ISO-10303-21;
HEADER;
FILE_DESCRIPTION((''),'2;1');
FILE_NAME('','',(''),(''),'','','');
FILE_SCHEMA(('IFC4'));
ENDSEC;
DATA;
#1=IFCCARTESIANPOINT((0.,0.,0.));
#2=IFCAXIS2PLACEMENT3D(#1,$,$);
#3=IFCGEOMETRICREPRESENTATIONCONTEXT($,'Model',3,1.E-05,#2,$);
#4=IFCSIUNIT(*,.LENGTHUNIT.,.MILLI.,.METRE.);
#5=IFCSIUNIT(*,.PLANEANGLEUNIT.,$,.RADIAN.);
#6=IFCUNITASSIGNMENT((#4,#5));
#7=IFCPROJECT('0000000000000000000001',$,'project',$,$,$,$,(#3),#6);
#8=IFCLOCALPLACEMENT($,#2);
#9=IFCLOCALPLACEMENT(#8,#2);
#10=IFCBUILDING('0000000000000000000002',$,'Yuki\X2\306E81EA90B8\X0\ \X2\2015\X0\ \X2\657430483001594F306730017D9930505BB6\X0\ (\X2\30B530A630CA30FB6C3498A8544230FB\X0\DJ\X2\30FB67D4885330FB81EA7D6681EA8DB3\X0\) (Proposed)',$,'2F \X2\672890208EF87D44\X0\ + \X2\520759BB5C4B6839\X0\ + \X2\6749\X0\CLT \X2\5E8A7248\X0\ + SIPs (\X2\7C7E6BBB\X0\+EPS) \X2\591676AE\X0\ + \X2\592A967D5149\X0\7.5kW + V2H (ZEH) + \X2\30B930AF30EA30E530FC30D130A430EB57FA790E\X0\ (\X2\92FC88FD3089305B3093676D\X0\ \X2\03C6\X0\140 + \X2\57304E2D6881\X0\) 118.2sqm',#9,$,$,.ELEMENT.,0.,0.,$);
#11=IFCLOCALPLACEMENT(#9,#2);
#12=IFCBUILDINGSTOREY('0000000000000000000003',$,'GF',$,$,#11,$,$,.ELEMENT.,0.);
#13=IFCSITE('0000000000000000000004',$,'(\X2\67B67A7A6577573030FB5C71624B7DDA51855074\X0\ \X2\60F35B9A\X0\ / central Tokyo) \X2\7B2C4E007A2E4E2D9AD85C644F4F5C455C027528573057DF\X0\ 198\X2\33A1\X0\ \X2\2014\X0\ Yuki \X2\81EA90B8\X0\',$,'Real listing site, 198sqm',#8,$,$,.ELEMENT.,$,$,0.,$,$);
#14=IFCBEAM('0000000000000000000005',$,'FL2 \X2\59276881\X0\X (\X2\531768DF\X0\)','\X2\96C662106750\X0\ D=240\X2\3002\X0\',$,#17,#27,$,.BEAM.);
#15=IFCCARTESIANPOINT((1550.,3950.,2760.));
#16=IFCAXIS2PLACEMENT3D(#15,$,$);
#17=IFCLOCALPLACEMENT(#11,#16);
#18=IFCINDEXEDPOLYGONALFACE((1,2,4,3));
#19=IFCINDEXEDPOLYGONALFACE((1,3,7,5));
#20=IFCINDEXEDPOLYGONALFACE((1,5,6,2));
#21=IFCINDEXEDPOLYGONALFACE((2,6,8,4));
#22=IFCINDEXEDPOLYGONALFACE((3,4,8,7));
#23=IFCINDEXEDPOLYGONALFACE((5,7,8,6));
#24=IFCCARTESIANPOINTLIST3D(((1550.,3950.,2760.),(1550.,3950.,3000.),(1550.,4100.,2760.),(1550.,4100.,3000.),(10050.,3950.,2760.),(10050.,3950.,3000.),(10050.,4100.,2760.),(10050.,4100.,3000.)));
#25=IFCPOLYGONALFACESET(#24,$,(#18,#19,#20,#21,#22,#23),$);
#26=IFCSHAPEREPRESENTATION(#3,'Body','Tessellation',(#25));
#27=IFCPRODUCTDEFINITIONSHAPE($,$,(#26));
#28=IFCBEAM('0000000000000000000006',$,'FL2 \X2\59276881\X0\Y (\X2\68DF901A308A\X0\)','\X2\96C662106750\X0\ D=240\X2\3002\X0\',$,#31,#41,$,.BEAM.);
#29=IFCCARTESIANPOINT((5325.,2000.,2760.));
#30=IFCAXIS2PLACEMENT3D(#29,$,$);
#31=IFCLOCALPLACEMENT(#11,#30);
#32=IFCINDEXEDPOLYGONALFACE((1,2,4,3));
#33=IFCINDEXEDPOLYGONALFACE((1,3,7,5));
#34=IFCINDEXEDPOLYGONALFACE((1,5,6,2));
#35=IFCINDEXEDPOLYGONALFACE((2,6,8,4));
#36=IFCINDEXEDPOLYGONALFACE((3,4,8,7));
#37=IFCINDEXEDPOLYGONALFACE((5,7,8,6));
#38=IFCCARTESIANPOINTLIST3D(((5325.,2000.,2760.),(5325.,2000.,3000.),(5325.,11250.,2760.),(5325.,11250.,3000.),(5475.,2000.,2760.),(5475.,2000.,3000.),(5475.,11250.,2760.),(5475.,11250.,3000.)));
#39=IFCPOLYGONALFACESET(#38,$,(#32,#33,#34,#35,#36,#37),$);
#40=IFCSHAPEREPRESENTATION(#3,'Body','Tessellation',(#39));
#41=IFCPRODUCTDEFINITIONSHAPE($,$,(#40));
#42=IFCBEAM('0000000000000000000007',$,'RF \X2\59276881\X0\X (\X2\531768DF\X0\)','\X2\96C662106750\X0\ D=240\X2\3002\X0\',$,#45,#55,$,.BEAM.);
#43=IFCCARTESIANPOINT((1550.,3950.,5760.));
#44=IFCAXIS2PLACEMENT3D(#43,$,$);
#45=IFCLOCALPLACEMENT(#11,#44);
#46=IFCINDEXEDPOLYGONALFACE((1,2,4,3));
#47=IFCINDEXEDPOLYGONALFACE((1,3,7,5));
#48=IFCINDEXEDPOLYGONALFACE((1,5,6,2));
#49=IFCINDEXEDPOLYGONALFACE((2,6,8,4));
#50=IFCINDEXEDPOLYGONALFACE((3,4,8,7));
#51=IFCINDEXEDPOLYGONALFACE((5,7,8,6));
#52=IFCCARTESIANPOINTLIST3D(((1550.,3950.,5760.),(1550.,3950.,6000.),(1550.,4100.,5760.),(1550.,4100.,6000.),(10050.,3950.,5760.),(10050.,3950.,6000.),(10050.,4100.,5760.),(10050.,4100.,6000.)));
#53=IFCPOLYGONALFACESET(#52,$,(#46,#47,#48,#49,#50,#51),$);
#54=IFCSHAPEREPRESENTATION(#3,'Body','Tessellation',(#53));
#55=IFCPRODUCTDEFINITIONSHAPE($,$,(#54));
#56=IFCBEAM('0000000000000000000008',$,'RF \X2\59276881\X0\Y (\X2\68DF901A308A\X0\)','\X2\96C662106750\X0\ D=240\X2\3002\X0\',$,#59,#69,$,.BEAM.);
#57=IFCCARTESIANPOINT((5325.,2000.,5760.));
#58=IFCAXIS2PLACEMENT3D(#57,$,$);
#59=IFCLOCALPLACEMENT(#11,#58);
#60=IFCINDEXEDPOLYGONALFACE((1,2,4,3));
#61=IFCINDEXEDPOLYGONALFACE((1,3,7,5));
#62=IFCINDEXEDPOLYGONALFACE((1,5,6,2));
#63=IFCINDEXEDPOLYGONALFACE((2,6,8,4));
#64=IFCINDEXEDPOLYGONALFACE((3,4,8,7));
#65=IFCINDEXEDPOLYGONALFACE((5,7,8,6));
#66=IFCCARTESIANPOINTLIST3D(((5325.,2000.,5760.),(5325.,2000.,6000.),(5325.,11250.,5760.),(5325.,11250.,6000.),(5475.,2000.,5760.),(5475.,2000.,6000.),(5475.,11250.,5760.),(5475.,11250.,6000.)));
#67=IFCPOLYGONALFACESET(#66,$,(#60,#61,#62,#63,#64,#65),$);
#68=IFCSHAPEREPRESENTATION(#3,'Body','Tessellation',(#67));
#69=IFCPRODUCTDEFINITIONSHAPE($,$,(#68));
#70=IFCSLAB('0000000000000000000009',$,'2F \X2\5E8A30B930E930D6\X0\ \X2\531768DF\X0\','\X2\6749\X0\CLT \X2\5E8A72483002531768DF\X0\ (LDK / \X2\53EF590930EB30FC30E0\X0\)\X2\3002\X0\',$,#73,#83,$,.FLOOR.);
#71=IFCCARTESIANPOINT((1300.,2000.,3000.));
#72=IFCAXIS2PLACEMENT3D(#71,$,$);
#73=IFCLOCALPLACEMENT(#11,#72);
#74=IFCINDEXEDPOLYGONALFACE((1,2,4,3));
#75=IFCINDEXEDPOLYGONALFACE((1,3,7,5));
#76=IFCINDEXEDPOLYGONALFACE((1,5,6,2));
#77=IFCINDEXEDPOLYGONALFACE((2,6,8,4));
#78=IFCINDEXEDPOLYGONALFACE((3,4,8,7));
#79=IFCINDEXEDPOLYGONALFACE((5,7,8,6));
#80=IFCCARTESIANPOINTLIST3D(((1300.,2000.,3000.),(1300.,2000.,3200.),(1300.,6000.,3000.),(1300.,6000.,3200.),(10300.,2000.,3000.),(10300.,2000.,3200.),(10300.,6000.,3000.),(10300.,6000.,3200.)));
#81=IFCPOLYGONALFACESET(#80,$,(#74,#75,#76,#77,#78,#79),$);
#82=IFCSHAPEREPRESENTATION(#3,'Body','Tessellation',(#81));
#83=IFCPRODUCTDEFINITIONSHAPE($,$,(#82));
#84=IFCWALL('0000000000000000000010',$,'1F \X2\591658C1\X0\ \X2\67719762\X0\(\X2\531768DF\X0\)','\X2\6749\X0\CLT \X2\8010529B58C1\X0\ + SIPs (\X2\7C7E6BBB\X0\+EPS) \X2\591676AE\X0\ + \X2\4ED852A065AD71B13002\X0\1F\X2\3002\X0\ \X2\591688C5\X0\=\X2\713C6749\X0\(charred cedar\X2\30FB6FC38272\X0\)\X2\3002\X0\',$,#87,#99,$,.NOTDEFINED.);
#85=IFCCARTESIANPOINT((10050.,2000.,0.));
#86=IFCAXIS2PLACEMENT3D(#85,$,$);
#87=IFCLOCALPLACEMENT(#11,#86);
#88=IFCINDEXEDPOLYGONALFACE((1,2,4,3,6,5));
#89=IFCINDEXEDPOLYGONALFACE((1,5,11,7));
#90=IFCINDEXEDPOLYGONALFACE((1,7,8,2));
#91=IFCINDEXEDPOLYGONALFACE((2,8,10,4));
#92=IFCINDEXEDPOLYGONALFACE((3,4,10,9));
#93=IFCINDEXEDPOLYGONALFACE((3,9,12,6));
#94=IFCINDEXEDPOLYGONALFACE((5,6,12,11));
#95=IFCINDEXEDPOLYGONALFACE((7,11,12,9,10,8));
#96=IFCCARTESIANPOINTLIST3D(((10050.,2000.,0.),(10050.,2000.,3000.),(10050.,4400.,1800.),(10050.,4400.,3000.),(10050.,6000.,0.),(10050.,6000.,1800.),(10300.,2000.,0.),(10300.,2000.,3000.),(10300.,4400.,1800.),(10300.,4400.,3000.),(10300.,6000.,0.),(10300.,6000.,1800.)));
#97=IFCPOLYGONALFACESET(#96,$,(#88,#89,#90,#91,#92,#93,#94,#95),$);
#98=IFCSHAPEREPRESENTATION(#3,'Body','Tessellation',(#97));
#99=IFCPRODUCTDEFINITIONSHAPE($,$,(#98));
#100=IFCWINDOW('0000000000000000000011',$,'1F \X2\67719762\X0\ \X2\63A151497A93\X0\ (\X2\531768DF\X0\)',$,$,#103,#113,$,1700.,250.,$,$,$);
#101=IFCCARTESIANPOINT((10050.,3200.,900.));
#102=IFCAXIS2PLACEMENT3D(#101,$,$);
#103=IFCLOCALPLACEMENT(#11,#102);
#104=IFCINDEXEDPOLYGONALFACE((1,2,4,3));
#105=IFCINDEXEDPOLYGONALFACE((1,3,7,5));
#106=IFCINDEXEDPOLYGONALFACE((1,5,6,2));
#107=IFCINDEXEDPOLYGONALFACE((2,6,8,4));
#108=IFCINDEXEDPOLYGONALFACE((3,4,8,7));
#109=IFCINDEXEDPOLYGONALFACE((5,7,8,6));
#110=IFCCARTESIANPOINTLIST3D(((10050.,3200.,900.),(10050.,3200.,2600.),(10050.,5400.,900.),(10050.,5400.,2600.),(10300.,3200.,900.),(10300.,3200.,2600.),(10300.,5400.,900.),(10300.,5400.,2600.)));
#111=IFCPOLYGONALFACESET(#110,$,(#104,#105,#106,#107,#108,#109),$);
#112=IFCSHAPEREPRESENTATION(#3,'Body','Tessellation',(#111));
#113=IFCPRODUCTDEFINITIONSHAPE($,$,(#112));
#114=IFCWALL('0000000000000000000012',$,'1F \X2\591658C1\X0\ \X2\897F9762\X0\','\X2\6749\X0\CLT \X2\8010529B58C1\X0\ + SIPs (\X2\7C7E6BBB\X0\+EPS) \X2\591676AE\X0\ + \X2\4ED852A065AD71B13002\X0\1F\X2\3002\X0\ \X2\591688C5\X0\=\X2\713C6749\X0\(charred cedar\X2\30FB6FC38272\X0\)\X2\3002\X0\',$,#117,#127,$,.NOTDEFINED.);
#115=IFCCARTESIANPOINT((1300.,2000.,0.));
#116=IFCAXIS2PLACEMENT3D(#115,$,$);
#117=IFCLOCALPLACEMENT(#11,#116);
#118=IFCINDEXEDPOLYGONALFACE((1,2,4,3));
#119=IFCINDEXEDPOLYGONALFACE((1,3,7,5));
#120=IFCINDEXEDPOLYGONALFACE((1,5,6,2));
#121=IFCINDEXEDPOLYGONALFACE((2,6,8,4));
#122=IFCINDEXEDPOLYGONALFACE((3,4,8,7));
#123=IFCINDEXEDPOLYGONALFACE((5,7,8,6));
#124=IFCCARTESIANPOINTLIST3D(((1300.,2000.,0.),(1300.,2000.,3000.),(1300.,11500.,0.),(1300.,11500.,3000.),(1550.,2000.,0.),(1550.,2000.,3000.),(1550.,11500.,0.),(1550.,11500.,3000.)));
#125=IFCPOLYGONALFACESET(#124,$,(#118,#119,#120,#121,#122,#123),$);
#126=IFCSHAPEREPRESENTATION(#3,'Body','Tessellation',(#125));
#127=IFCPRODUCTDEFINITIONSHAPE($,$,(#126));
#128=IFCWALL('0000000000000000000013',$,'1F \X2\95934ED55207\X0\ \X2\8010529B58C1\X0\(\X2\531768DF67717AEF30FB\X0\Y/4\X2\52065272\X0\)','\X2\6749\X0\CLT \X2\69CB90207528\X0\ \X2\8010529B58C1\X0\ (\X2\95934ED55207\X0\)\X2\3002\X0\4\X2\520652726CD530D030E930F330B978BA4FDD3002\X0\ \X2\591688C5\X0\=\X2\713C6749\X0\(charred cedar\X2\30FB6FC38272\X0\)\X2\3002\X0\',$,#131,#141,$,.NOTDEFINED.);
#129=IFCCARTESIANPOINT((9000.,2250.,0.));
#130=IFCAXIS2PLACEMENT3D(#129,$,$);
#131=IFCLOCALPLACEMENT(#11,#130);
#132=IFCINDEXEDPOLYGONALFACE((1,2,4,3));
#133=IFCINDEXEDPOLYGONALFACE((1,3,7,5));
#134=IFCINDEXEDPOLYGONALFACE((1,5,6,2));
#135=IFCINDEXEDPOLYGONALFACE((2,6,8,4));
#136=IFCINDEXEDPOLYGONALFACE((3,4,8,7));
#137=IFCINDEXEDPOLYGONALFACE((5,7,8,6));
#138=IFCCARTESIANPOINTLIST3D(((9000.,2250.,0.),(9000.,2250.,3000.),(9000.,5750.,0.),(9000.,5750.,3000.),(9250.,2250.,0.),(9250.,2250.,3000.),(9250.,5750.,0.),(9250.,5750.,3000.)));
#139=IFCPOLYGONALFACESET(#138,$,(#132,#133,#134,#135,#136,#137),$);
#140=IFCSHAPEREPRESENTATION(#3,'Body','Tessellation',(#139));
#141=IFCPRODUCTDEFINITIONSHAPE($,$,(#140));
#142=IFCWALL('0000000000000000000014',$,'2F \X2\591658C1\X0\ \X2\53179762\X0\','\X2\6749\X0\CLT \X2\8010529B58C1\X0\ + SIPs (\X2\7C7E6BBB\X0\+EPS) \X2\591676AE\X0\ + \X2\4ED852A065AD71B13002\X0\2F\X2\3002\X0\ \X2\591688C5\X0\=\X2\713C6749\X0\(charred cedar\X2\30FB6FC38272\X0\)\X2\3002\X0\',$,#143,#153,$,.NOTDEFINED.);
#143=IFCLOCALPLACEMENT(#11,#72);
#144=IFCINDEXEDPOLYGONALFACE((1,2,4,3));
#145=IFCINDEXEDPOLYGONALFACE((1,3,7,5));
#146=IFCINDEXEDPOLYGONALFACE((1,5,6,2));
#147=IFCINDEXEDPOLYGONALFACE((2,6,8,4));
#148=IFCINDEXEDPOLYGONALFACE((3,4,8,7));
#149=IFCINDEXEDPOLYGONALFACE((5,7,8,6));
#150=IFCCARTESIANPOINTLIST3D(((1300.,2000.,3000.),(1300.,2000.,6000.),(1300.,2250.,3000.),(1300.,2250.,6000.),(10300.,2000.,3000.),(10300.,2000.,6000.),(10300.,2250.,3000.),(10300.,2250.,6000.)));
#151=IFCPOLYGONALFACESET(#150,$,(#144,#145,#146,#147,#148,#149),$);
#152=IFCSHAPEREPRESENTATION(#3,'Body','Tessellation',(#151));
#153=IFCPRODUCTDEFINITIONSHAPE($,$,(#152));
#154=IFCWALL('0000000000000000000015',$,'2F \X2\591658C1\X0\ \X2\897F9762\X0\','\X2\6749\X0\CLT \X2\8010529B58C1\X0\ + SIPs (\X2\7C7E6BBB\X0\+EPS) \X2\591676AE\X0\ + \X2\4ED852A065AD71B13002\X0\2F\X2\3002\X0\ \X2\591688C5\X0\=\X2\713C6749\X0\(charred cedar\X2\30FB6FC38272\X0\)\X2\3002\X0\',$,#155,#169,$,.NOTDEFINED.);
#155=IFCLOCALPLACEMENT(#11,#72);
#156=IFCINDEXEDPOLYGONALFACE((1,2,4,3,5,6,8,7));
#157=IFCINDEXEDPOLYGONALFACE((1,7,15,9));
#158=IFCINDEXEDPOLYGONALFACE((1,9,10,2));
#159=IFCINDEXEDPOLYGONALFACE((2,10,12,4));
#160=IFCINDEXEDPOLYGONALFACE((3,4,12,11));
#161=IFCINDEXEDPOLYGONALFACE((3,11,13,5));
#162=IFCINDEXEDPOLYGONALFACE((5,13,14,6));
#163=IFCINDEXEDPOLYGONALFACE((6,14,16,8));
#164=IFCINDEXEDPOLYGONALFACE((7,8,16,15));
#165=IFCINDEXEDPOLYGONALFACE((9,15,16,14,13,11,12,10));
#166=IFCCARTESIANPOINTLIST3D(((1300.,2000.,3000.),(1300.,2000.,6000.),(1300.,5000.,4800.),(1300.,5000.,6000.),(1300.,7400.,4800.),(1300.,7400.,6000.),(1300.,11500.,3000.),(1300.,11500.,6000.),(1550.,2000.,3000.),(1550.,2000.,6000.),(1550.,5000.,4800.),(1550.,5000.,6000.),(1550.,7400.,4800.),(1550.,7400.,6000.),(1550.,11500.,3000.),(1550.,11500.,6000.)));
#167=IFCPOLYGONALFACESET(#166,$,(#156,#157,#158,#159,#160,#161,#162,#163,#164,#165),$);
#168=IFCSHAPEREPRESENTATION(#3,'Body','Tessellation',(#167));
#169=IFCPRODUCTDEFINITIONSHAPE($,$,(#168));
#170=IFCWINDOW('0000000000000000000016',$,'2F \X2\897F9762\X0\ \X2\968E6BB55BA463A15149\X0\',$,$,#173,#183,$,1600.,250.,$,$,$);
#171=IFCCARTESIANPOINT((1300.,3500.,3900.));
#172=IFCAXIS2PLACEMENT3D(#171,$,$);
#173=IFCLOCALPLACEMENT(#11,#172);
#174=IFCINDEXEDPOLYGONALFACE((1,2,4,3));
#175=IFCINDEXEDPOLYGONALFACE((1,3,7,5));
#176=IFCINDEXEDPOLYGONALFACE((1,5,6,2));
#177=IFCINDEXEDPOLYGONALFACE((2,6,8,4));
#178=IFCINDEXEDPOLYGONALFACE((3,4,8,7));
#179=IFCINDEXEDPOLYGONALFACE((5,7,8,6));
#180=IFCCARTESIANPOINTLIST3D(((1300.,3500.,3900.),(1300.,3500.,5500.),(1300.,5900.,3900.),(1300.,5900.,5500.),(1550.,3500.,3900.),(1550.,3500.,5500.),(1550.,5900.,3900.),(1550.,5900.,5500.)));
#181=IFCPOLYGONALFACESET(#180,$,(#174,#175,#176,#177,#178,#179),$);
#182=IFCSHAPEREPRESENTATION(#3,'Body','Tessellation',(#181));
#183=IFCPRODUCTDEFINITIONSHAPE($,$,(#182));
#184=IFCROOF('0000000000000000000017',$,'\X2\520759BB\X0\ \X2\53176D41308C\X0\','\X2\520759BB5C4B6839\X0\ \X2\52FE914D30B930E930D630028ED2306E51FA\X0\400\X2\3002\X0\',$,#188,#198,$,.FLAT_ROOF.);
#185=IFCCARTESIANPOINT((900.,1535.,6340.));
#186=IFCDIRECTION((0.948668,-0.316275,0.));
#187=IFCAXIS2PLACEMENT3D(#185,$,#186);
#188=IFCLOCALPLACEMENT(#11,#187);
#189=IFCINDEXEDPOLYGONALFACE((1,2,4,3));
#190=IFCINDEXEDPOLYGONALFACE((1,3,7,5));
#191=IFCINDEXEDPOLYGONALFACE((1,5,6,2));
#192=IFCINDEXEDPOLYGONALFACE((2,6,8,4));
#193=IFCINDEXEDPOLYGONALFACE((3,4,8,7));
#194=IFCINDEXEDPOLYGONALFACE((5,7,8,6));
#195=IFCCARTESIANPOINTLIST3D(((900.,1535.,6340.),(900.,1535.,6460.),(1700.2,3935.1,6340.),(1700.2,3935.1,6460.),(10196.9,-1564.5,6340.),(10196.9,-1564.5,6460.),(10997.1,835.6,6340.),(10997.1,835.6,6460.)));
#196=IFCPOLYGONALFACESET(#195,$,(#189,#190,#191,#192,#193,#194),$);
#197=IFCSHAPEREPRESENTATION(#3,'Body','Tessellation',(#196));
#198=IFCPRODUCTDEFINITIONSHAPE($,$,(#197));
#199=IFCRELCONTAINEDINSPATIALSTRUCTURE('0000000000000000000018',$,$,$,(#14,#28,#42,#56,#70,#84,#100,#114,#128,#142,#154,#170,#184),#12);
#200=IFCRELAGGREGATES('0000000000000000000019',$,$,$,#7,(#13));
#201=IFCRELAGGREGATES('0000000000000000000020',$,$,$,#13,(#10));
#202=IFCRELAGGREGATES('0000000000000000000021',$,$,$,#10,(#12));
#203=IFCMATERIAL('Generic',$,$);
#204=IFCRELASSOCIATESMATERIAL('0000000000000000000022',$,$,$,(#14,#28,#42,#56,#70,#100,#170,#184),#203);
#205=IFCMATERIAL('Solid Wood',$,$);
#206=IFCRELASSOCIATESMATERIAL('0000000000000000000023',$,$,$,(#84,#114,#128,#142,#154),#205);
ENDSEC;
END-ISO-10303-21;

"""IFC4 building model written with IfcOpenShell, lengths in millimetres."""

from ifc_helpers import new_model, si_unit, frame, frame_2d, origin, place, context, project, spatial, rectangle, extrude, material, element, fill, save


model = new_model("IFC4")

# Units and contexts
model_context = context("Model", 3, precision=1e-05, world=origin())
ifc_project = project(units=[si_unit("LENGTHUNIT", "METRE", prefix="MILLI"), si_unit("PLANEANGLEUNIT", "RADIAN")], contexts=[model_context])

# Site, building, storey
site_placement = place(None, origin())
site = spatial("IfcSite", under=ifc_project, at=site_placement, Name="(架空敷地・山手線内側 想定 / central Tokyo) 第一種中高層住居専用地域 198㎡ — Yuki 自邸", ObjectType="Real listing site, 198sqm", CompositionType="ELEMENT", RefElevation=0.0)
building_placement = place(site_placement, origin())
building = spatial("IfcBuilding", under=site, at=building_placement, Name="Yukiの自邸 ― 整え、奏で、継ぐ家 (サウナ・水風呂・DJ・柔術・自給自足) (Proposed)", ObjectType="2F 木造軸組 + 切妻屋根 + 杉CLT 床版 + SIPs (籾殻+EPS) 外皮 + 太陽光7.5kW + V2H (ZEH) + スクリューパイル基礎 (鋼製らせん杭 φ140 + 地中梁) 118.2sqm", CompositionType="ELEMENT", ElevationOfRefHeight=0.0, ElevationOfTerrain=0.0)
storey_placement = place(building_placement, origin())
storey = spatial("IfcBuildingStorey", under=building, at=storey_placement, Name="GF", CompositionType="ELEMENT", Elevation=0.0)

# Shared definitions
ifc_material_1 = material(Name="Generic")

# Beams
beam_1_placement = place(storey_placement, frame((1550.0, 3950.0, 2760.0)))
element("IfcBeam", 1, at=beam_1_placement, inside=storey, material=ifc_material_1, Name="FL2 大梁X (北棟)", Description="集成材 D=240。", PredefinedType="BEAM", context=model_context, shape_type="SweptSolid", body=[
    extrude(rectangle(XDim=8500.0, YDim=150.0, at=frame_2d((4250.0, 75.0))), frame((1550.0, 3950.0, 2760.0)), (0.0, 0.0, 1.0), 240.0),
])
beam_2_placement = place(storey_placement, frame((5325.0, 2000.0, 2760.0)))
element("IfcBeam", 2, at=beam_2_placement, inside=storey, material=ifc_material_1, Name="FL2 大梁Y (棟通り)", Description="集成材 D=240。", PredefinedType="BEAM", context=model_context, shape_type="SweptSolid", body=[
    extrude(rectangle(XDim=150.0, YDim=9250.0, at=frame_2d((75.0, 4625.0))), frame((5325.0, 2000.0, 2760.0)), (0.0, 0.0, 1.0), 240.0),
])
beam_3_placement = place(storey_placement, frame((1550.0, 3950.0, 5760.0)))
element("IfcBeam", 3, at=beam_3_placement, inside=storey, material=ifc_material_1, Name="RF 大梁X (北棟)", Description="集成材 D=240。", PredefinedType="BEAM", context=model_context, shape_type="SweptSolid", body=[
    extrude(rectangle(XDim=8500.0, YDim=150.0, at=frame_2d((4250.0, 75.0))), frame((1550.0, 3950.0, 5760.0)), (0.0, 0.0, 1.0), 240.0),
])
beam_4_placement = place(storey_placement, frame((5325.0, 2000.0, 5760.0)))
element("IfcBeam", 4, at=beam_4_placement, inside=storey, material=ifc_material_1, Name="RF 大梁Y (棟通り)", Description="集成材 D=240。", PredefinedType="BEAM", context=model_context, shape_type="SweptSolid", body=[
    extrude(rectangle(XDim=150.0, YDim=9250.0, at=frame_2d((75.0, 4625.0))), frame((5325.0, 2000.0, 5760.0)), (0.0, 0.0, 1.0), 240.0),
])

# Slab
slab_1_placement = place(storey_placement, frame((1300.0, 2000.0, 3000.0)))
element("IfcSlab", 5, at=slab_1_placement, inside=storey, material=ifc_material_1, Name="2F 床スラブ 北棟", Description="杉CLT 床版。北棟 (LDK / 可変ルーム)。", PredefinedType="FLOOR", context=model_context, shape_type="SweptSolid", body=[
    extrude(rectangle(XDim=9000.0, YDim=4000.0, at=frame_2d((4500.0, 2000.0))), frame((1300.0, 2000.0, 3000.0)), (0.0, 0.0, 1.0), 200.0),
])

# Wall, opening, window
ifc_material_2 = material(Name="Solid Wood")
wall_1_placement = place(storey_placement, frame((10050.0, 2000.0, 0.0)))
wall_1 = element("IfcWall", 6, at=wall_1_placement, inside=storey, material=ifc_material_2, Name="1F 外壁 東面(北棟)", Description="杉CLT 耐力壁 + SIPs (籾殻+EPS) 外皮 + 付加断熱。1F。 外装=焼杉(charred cedar・濃色)。", PredefinedType="NOTDEFINED", context=model_context, shape_type="SweptSolid", body=[
    extrude(rectangle(XDim=250.0, YDim=4000.0, at=frame_2d((125.0, 2000.0))), frame((10050.0, 2000.0, 0.0)), (0.0, 0.0, 1.0), 3000.0),
])
opening_1_placement = place(storey_placement, frame((10050.0, 3200.0, 900.0)))
opening_1 = element("IfcOpeningElement", 7, at=opening_1_placement, cuts=wall_1, PredefinedType="NOTDEFINED", context=model_context, shape_type="SweptSolid", body=[
    extrude(rectangle(XDim=250.0, YDim=2200.0, at=frame_2d((125.0, 1100.0))), frame((10050.0, 3200.0, 900.0)), (0.0, 0.0, 1.0), 1700.0),
])
window_1_placement = place(storey_placement, frame((10050.0, 3200.0, 900.0)))
window_1 = element("IfcWindow", 8, at=window_1_placement, inside=storey, material=ifc_material_1, Name="1F 東面 採光窓 (北棟)", OverallHeight=1700.0, OverallWidth=250.0, context=model_context, shape_type="SweptSolid", body=[
    extrude(rectangle(XDim=250.0, YDim=2200.0, at=frame_2d((125.0, 1100.0))), frame((10050.0, 3200.0, 900.0)), (0.0, 0.0, 1.0), 1700.0),
])
fill(opening_1, window_1)

# Walls
wall_2_placement = place(storey_placement, frame((1300.0, 2000.0, 0.0)))
element("IfcWall", 9, at=wall_2_placement, inside=storey, material=ifc_material_2, Name="1F 外壁 西面", Description="杉CLT 耐力壁 + SIPs (籾殻+EPS) 外皮 + 付加断熱。1F。 外装=焼杉(charred cedar・濃色)。", PredefinedType="NOTDEFINED", context=model_context, shape_type="SweptSolid", body=[
    extrude(rectangle(XDim=250.0, YDim=9500.0, at=frame_2d((125.0, 4750.0))), frame((1300.0, 2000.0, 0.0)), (0.0, 0.0, 1.0), 3000.0),
])
wall_3_placement = place(storey_placement, frame((9000.0, 2250.0, 0.0)))
element("IfcWall", 10, at=wall_3_placement, inside=storey, material=ifc_material_2, Name="1F 間仕切 耐力壁(北棟東端・Y/4分割)", Description="杉CLT 構造用 耐力壁 (間仕切)。4分割法バランス確保。 外装=焼杉(charred cedar・濃色)。", PredefinedType="NOTDEFINED", context=model_context, shape_type="SweptSolid", body=[
    extrude(rectangle(XDim=250.0, YDim=3500.0, at=frame_2d((125.0, 1750.0))), frame((9000.0, 2250.0, 0.0)), (0.0, 0.0, 1.0), 3000.0),
])
wall_4_placement = place(storey_placement, frame((1300.0, 2000.0, 3000.0)))
element("IfcWall", 11, at=wall_4_placement, inside=storey, material=ifc_material_2, Name="2F 外壁 北面", Description="杉CLT 耐力壁 + SIPs (籾殻+EPS) 外皮 + 付加断熱。2F。 外装=焼杉(charred cedar・濃色)。", PredefinedType="NOTDEFINED", context=model_context, shape_type="SweptSolid", body=[
    extrude(rectangle(XDim=9000.0, YDim=250.0, at=frame_2d((4500.0, 125.0))), frame((1300.0, 2000.0, 3000.0)), (0.0, 0.0, 1.0), 3000.0),
])

# Wall, opening, window
wall_5_placement = place(storey_placement, frame((1300.0, 2000.0, 3000.0)))
wall_5 = element("IfcWall", 12, at=wall_5_placement, inside=storey, material=ifc_material_2, Name="2F 外壁 西面", Description="杉CLT 耐力壁 + SIPs (籾殻+EPS) 外皮 + 付加断熱。2F。 外装=焼杉(charred cedar・濃色)。", PredefinedType="NOTDEFINED", context=model_context, shape_type="SweptSolid", body=[
    extrude(rectangle(XDim=250.0, YDim=9500.0, at=frame_2d((125.0, 4750.0))), frame((1300.0, 2000.0, 3000.0)), (0.0, 0.0, 1.0), 3000.0),
])
opening_2_placement = place(storey_placement, frame((1300.0, 3500.0, 3900.0)))
opening_2 = element("IfcOpeningElement", 13, at=opening_2_placement, cuts=wall_5, PredefinedType="NOTDEFINED", context=model_context, shape_type="SweptSolid", body=[
    extrude(rectangle(XDim=250.0, YDim=2400.0, at=frame_2d((125.0, 1200.0))), frame((1300.0, 3500.0, 3900.0)), (0.0, 0.0, 1.0), 1600.0),
])
window_2_placement = place(storey_placement, frame((1300.0, 3500.0, 3900.0)))
window_2 = element("IfcWindow", 14, at=window_2_placement, inside=storey, material=ifc_material_1, Name="2F 西面 階段室採光", OverallHeight=1600.0, OverallWidth=250.0, context=model_context, shape_type="SweptSolid", body=[
    extrude(rectangle(XDim=250.0, YDim=2400.0, at=frame_2d((125.0, 1200.0))), frame((1300.0, 3500.0, 3900.0)), (0.0, 0.0, 1.0), 1600.0),
])
fill(opening_2, window_2)

# Roof
roof_1_placement = place(storey_placement, frame((900.0, 1535.0, 6340.0), x_axis=(0.948668, -0.316275, 0.0)))
element("IfcRoof", 15, at=roof_1_placement, inside=storey, material=ifc_material_1, Name="切妻 北流れ", Description="切妻屋根 勾配スラブ。軒の出400。", PredefinedType="FLAT_ROOF", context=model_context, shape_type="SweptSolid", body=[
    extrude(rectangle(XDim=9800.0, YDim=2530.0, at=frame_2d((4900.0, 1265.0))), frame((900.0, 1535.0, 6340.0), x_axis=(0.948668, -0.316275, 0.0)), (0.0, 0.0, 1.0), 120.0),
])

save(model, "model.ifc")
